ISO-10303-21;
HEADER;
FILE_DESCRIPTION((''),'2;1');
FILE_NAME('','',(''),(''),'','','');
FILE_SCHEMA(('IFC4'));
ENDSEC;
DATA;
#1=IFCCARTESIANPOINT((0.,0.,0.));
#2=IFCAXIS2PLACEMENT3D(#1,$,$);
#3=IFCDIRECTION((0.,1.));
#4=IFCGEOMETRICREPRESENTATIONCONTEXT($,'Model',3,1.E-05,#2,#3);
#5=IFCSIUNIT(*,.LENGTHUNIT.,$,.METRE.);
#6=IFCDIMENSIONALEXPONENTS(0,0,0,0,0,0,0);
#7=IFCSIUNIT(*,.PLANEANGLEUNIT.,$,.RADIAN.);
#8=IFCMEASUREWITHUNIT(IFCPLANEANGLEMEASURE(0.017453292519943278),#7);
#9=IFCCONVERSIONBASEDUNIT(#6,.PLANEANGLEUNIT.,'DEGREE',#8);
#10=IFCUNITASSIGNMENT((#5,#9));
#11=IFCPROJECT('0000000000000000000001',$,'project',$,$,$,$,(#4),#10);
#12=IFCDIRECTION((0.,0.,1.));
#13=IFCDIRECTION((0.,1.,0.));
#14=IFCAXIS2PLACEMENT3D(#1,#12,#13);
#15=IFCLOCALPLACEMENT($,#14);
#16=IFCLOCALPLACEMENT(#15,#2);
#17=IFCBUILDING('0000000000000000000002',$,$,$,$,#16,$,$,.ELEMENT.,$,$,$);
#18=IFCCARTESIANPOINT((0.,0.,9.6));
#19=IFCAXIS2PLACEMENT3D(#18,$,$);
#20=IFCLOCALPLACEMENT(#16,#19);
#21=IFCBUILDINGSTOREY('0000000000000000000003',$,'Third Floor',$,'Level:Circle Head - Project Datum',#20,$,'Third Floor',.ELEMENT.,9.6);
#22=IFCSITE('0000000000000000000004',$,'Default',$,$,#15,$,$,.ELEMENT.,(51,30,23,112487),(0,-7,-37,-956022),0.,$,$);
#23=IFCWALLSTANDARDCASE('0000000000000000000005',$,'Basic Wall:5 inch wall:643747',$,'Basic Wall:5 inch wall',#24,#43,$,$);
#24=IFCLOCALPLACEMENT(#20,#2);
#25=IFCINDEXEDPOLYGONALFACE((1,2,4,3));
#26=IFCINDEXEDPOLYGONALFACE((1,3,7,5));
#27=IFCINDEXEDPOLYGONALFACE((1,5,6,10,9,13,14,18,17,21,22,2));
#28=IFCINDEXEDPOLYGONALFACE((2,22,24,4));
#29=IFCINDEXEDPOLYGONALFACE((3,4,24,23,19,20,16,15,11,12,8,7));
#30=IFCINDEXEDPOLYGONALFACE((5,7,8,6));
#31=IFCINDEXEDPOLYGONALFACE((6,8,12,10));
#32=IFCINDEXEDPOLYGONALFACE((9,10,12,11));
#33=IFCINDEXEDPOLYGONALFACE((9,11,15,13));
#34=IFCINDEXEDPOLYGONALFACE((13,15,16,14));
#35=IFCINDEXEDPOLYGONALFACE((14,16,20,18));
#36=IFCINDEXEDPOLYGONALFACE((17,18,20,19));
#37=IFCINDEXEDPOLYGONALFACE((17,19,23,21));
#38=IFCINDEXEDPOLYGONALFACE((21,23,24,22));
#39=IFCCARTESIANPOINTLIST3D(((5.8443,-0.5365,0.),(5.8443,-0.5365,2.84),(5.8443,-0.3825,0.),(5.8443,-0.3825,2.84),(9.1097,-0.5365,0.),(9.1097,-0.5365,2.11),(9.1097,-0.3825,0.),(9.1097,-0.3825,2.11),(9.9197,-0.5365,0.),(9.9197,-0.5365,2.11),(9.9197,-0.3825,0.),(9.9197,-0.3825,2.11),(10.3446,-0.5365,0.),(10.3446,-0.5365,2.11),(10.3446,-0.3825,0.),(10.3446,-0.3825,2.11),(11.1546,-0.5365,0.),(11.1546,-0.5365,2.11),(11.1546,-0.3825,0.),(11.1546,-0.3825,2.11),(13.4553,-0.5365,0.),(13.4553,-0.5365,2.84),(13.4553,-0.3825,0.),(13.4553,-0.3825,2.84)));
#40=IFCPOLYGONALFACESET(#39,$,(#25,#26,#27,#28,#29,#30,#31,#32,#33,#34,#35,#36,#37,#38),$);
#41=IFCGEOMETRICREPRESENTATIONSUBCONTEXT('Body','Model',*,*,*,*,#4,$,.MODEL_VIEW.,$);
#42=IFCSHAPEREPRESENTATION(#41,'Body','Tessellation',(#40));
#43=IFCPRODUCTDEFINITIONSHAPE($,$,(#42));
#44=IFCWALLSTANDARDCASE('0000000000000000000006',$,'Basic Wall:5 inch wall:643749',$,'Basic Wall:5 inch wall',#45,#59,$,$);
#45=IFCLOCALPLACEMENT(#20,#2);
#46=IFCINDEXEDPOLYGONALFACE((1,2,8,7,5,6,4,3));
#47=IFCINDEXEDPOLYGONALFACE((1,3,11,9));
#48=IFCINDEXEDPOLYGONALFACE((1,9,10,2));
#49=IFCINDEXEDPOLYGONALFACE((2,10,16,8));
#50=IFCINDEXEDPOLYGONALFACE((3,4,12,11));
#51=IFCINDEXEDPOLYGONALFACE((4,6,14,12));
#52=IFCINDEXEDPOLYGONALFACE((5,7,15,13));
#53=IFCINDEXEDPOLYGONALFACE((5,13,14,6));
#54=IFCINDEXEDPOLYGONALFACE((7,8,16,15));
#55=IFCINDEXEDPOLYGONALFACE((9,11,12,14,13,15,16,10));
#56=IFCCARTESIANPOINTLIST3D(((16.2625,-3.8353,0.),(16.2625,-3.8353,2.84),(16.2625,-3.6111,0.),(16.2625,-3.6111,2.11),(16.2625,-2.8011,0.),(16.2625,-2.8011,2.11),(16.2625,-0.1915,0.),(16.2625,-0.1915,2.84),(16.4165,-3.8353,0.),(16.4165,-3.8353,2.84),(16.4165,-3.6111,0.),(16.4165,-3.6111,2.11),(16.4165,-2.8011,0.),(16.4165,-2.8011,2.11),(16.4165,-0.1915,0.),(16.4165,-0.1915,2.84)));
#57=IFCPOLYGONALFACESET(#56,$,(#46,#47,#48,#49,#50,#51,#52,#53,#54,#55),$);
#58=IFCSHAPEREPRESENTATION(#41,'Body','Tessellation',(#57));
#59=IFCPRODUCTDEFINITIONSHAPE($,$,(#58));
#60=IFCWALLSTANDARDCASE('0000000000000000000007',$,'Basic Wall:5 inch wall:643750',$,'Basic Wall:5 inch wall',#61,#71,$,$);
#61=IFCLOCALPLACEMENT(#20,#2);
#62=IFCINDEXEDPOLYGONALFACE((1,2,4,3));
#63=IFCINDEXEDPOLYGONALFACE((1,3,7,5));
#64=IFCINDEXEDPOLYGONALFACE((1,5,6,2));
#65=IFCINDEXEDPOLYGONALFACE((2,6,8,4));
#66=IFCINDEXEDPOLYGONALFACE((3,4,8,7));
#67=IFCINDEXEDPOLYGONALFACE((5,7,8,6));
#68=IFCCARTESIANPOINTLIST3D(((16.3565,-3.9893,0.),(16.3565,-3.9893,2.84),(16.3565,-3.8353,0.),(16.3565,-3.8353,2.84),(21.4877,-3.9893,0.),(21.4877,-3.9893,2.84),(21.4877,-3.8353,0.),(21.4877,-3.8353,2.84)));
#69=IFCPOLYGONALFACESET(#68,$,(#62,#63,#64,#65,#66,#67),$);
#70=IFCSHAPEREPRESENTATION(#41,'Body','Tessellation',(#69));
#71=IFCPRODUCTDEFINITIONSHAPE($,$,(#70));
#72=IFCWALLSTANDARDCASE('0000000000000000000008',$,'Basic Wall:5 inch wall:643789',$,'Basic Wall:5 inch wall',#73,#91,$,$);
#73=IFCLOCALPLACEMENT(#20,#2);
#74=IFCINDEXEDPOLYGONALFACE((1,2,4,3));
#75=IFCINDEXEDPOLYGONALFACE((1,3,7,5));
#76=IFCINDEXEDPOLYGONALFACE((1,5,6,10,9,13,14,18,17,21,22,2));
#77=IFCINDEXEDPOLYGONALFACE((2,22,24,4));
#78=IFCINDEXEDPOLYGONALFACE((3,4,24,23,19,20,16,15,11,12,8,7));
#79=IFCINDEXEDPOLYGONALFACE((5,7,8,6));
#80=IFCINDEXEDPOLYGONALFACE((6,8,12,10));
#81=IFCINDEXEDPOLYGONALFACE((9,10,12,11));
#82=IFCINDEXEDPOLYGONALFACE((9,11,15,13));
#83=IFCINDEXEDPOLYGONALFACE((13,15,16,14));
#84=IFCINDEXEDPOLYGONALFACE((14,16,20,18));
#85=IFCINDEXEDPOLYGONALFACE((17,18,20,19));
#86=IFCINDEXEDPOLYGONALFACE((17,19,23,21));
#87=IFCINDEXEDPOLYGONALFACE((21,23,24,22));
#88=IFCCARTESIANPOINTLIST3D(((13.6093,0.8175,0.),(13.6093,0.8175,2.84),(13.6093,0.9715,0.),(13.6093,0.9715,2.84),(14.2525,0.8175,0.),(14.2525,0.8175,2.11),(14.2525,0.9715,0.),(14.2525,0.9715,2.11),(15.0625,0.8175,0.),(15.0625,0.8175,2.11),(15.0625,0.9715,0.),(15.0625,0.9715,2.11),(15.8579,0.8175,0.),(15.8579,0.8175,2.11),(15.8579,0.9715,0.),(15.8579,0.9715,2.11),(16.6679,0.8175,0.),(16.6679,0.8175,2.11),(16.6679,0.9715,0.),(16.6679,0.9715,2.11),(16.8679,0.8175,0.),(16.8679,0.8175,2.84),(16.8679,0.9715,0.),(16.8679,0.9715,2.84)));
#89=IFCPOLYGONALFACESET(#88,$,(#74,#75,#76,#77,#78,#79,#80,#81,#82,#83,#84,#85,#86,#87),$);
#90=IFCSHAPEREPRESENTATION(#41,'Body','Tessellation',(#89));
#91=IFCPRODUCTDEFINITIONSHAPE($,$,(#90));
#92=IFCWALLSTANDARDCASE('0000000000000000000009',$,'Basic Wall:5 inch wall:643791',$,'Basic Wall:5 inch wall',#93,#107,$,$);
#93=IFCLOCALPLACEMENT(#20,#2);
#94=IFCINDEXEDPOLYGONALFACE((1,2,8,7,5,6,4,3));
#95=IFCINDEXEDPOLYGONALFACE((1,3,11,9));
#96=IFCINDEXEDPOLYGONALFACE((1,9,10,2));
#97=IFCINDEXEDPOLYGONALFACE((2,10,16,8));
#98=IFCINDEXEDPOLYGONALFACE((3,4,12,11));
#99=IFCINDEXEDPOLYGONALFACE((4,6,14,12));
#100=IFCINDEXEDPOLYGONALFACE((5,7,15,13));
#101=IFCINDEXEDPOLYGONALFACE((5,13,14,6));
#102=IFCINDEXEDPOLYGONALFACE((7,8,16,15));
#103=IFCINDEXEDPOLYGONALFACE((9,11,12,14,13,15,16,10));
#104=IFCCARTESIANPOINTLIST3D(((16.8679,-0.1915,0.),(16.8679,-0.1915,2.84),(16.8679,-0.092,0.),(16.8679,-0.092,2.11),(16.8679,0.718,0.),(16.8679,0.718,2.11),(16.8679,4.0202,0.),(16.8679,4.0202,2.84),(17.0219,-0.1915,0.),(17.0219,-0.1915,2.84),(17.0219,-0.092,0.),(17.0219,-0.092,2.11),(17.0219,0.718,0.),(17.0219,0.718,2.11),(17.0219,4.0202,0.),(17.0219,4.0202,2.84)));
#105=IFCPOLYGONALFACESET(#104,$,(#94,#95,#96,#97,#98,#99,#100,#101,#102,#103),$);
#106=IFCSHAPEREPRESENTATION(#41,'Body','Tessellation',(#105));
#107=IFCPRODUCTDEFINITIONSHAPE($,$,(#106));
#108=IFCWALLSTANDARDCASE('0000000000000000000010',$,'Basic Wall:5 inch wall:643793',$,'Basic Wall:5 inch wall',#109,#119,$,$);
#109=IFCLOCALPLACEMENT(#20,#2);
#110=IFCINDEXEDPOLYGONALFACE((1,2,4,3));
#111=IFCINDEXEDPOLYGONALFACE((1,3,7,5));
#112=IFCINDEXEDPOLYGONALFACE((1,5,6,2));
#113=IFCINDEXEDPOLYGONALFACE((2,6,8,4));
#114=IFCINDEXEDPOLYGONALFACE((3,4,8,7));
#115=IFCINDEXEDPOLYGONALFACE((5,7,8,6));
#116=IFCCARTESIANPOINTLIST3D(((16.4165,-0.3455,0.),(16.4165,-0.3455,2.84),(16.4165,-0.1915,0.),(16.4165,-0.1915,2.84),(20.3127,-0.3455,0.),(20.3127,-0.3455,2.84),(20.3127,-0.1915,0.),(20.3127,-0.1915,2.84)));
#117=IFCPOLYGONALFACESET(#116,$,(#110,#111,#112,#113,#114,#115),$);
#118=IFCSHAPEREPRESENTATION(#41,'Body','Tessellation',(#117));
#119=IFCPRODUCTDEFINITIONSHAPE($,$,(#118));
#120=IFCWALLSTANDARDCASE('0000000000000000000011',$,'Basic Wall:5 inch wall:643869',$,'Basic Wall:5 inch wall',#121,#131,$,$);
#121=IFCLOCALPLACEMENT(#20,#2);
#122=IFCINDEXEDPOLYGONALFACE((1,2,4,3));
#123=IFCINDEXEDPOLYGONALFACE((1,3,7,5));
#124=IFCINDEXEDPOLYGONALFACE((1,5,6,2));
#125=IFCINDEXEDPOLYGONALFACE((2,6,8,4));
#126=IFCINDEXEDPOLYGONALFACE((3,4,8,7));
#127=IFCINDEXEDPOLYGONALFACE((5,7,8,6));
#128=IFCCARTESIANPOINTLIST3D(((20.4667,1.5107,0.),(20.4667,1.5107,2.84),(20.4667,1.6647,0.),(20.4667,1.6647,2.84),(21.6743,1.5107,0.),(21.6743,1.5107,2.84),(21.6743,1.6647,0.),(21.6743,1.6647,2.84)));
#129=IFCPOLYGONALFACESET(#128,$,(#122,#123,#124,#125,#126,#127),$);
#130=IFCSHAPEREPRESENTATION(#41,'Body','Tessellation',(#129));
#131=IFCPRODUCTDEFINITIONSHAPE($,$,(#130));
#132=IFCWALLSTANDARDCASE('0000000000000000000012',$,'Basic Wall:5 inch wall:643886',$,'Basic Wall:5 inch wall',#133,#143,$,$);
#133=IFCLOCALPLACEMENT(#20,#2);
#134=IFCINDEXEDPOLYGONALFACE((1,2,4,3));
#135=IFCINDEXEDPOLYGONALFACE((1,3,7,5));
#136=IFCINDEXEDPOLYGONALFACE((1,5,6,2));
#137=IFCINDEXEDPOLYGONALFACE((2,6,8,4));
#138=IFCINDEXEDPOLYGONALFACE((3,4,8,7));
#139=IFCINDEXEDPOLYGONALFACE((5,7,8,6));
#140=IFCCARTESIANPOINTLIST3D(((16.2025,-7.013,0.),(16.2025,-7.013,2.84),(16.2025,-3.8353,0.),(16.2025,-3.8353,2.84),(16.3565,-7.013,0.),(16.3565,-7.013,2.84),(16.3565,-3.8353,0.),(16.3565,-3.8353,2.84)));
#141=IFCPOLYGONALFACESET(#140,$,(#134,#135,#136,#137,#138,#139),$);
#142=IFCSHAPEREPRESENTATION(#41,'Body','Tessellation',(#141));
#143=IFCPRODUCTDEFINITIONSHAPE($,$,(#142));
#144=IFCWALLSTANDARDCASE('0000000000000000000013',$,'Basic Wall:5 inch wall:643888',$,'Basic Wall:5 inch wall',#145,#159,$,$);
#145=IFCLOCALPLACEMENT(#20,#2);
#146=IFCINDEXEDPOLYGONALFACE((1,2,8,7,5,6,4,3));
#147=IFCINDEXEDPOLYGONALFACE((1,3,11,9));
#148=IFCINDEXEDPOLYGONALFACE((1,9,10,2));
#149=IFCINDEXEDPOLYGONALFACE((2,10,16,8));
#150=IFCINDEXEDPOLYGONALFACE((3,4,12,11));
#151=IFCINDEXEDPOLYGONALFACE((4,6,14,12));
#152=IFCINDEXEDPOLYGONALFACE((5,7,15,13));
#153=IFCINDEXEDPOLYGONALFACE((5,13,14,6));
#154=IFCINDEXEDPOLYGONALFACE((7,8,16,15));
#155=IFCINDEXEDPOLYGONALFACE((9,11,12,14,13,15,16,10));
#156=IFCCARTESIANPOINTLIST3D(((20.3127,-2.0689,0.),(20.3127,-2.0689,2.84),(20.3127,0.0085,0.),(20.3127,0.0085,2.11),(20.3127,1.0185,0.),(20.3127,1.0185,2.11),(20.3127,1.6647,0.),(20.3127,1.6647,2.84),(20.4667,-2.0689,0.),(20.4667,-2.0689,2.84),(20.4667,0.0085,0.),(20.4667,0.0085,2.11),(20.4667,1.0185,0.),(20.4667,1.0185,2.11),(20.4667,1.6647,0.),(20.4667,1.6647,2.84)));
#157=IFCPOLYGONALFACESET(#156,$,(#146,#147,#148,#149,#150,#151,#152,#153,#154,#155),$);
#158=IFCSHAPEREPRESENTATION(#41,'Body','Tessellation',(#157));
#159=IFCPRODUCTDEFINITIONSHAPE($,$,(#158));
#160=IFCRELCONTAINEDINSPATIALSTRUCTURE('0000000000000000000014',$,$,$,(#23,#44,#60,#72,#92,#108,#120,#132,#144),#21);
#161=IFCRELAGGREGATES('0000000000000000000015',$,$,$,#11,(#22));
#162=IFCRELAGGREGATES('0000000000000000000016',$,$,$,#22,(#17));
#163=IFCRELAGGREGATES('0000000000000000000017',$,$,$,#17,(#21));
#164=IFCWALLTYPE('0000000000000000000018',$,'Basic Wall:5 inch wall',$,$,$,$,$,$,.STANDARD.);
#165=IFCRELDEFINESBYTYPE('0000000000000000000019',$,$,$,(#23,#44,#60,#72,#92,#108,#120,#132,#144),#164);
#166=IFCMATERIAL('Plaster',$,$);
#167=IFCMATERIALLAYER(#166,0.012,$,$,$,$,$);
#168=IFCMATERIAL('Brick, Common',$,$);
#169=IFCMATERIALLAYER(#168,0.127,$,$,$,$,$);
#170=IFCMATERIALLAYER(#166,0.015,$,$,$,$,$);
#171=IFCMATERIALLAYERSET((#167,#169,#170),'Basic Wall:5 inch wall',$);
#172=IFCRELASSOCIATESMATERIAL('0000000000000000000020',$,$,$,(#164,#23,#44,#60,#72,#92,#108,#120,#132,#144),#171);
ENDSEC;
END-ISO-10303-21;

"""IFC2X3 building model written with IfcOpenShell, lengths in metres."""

from ifc_helpers import new_model, entity, si_unit, converted_unit, direction, frame, frame_2d, origin, place, context, subcontext, project, spatial, rectangle, extrude, material, layer, layer_set, layer_usage, type_object, element, save


model = new_model("IFC2X3")

# Units and contexts
model_context = context("Model", 3, precision=1e-05, world=origin(), true_north=direction((0.0, 1.0)))
body_context = subcontext(model_context, "Body", "Model", "MODEL_VIEW")
ifc_project = project(units=[si_unit("LENGTHUNIT", "METRE"), converted_unit("PLANEANGLEUNIT", "DEGREE", entity("IfcPlaneAngleMeasure", 0.017453292519943278), si_unit("PLANEANGLEUNIT", "RADIAN"), dimensions=[0, 0, 0, 0, 0, 0, 0])], contexts=[model_context])

# Site, building, storey
site_placement = place(None, frame((0.0, 0.0, 0.0), z_axis=(0.0, 0.0, 1.0), x_axis=(0.0, 1.0, 0.0)))
site = spatial("IfcSite", under=ifc_project, at=site_placement, Name="Default", CompositionType="ELEMENT", RefLatitude=(51, 30, 23, 112487), RefLongitude=(0, -7, -37, -956022), RefElevation=0.0)
building_placement = place(site_placement, origin())
building = spatial("IfcBuilding", under=site, at=building_placement, CompositionType="ELEMENT")
storey_placement = place(building_placement, frame((0.0, 0.0, 9.6)))
storey = spatial("IfcBuildingStorey", under=building, at=storey_placement, Name="Third Floor", ObjectType="Level:Circle Head - Project Datum", LongName="Third Floor", CompositionType="ELEMENT", Elevation=9.6)

# Wall, openings
ifc_material_1 = material(Name="Plaster")
ifc_layer_1 = layer(ifc_material_1, 0.012)
ifc_material_2 = material(Name="Brick, Common")
ifc_layer_2 = layer(ifc_material_2, 0.127)
ifc_layer_3 = layer(ifc_material_1, 0.015)
ifc_layer_set = layer_set([ifc_layer_1, ifc_layer_2, ifc_layer_3], Name="Basic Wall:5 inch wall")
ifc_layer_usage_1 = layer_usage(ifc_layer_set, "AXIS2", "NEGATIVE", 0.077)
wall_type = type_object("IfcWallType", Name="Basic Wall:5 inch wall", PredefinedType="STANDARD", material=ifc_layer_set)
wall_1_placement = place(storey_placement, frame((13.4553, -0.4595, 0.0), z_axis=(0.0, 0.0, 1.0), x_axis=(-1.0, 0.0, 0.0)))
wall_1 = element("IfcWallStandardCase", 1, at=wall_1_placement, inside=storey, type_object=wall_type, material=ifc_layer_usage_1, Name="Basic Wall:5 inch wall:643747", ObjectType="Basic Wall:5 inch wall", context=body_context, shape_type="SweptSolid", body=[
    extrude(rectangle(XDim=7.611, YDim=0.154, at=frame_2d((3.8055, 0.0), x_axis=(1.0, 0.0))), origin(), (0.0, 0.0, 1.0), 2.84),
])
opening_1_placement = place(wall_1_placement, frame((4.3456, 0.077, 0.0)))
element("IfcOpeningElement", 2, at=opening_1_placement, cuts=wall_1, ObjectType="Opening", context=body_context, shape_type="SweptSolid", body=[
    extrude(rectangle(XDim=2.11, YDim=0.81, at=frame_2d((1.055, 0.405), x_axis=(1.0, 0.0))), frame((0.0, 0.0, 0.0), z_axis=(0.0, -1.0, 0.0), x_axis=(0.0, 0.0, 1.0)), (0.0, 0.0, 1.0), 0.154),
])
opening_2_placement = place(wall_1_placement, frame((3.1107, 0.077, 0.0)))
element("IfcOpeningElement", 3, at=opening_2_placement, cuts=wall_1, ObjectType="Opening", context=body_context, shape_type="SweptSolid", body=[
    extrude(rectangle(XDim=2.11, YDim=0.81, at=frame_2d((1.055, 0.405), x_axis=(1.0, 0.0))), frame((0.0, 0.0, 0.0), z_axis=(0.0, -1.0, 0.0), x_axis=(0.0, 0.0, 1.0)), (0.0, 0.0, 1.0), 0.154),
])

# Wall, opening
ifc_layer_usage_2 = layer_usage(ifc_layer_set, "AXIS2", "NEGATIVE", 0.077)
wall_2_placement = place(storey_placement, frame((16.3395, -0.1915, 0.0), z_axis=(0.0, 0.0, 1.0), x_axis=(0.0, -1.0, 0.0)))
wall_2 = element("IfcWallStandardCase", 4, at=wall_2_placement, inside=storey, type_object=wall_type, material=ifc_layer_usage_2, Name="Basic Wall:5 inch wall:643749", ObjectType="Basic Wall:5 inch wall", context=body_context, shape_type="SweptSolid", body=[
    extrude(rectangle(XDim=3.6438, YDim=0.154, at=frame_2d((1.8219, 0.0), x_axis=(1.0, 0.0))), origin(), (0.0, 0.0, 1.0), 2.84),
])
opening_3_placement = place(wall_2_placement, frame((3.4196, 0.077, 0.0)))
element("IfcOpeningElement", 5, at=opening_3_placement, cuts=wall_2, ObjectType="Opening", context=body_context, shape_type="SweptSolid", body=[
    extrude(rectangle(XDim=2.11, YDim=0.81, at=frame_2d((1.055, 0.405), x_axis=(1.0, 0.0))), frame((0.0, 0.0, 0.0), z_axis=(0.0, -1.0, 0.0), x_axis=(0.0, 0.0, 1.0)), (0.0, 0.0, 1.0), 0.154),
])

# Wall
ifc_layer_usage_3 = layer_usage(ifc_layer_set, "AXIS2", "NEGATIVE", 0.077)
wall_3_placement = place(storey_placement, frame((16.3565, -3.9123, 0.0)))
element("IfcWallStandardCase", 6, at=wall_3_placement, inside=storey, type_object=wall_type, material=ifc_layer_usage_3, Name="Basic Wall:5 inch wall:643750", ObjectType="Basic Wall:5 inch wall", context=body_context, shape_type="SweptSolid", body=[
    extrude(rectangle(XDim=5.1312, YDim=0.154, at=frame_2d((2.5656, 0.0), x_axis=(-1.0, 0.0))), origin(), (0.0, 0.0, 1.0), 2.84),
])

# Wall, openings
ifc_layer_usage_4 = layer_usage(ifc_layer_set, "AXIS2", "NEGATIVE", 0.077)
wall_4_placement = place(storey_placement, frame((13.6093, 0.8945, 0.0)))
wall_4 = element("IfcWallStandardCase", 7, at=wall_4_placement, inside=storey, type_object=wall_type, material=ifc_layer_usage_4, Name="Basic Wall:5 inch wall:643789", ObjectType="Basic Wall:5 inch wall", context=body_context, shape_type="SweptSolid", body=[
    extrude(rectangle(XDim=3.2586, YDim=0.154, at=frame_2d((1.6293, 0.0), x_axis=(-1.0, 0.0))), origin(), (0.0, 0.0, 1.0), 2.84),
])
opening_4_placement = place(wall_4_placement, frame((1.4532, 0.077, 0.0)))
element("IfcOpeningElement", 8, at=opening_4_placement, cuts=wall_4, ObjectType="Opening", context=body_context, shape_type="SweptSolid", body=[
    extrude(rectangle(XDim=2.11, YDim=0.81, at=frame_2d((1.055, 0.405), x_axis=(1.0, 0.0))), frame((0.0, 0.0, 0.0), z_axis=(0.0, -1.0, 0.0), x_axis=(0.0, 0.0, 1.0)), (0.0, 0.0, 1.0), 0.154),
])
opening_5_placement = place(wall_4_placement, frame((2.2486, -0.077, 0.0)))
element("IfcOpeningElement", 9, at=opening_5_placement, cuts=wall_4, ObjectType="Opening", context=body_context, shape_type="SweptSolid", body=[
    extrude(rectangle(XDim=2.11, YDim=0.81, at=frame_2d((1.055, 0.405), x_axis=(1.0, 0.0))), frame((0.0, 0.0, 0.0), z_axis=(0.0, 1.0, 0.0), x_axis=(0.0, 0.0, 1.0)), (0.0, 0.0, 1.0), 0.154),
])

# Wall, opening
ifc_layer_usage_5 = layer_usage(ifc_layer_set, "AXIS2", "NEGATIVE", 0.077)
wall_5_placement = place(storey_placement, frame((16.9449, -0.1915, 0.0), z_axis=(0.0, 0.0, 1.0), x_axis=(0.0, 1.0, 0.0)))
wall_5 = element("IfcWallStandardCase", 10, at=wall_5_placement, inside=storey, type_object=wall_type, material=ifc_layer_usage_5, Name="Basic Wall:5 inch wall:643791", ObjectType="Basic Wall:5 inch wall", context=body_context, shape_type="SweptSolid", body=[
    extrude(rectangle(XDim=4.2118, YDim=0.154, at=frame_2d((2.1059, 0.0), x_axis=(-1.0, 0.0))), origin(), (0.0, 0.0, 1.0), 2.84),
])
opening_6_placement = place(wall_5_placement, frame((0.9095, 0.077, 0.0)))
element("IfcOpeningElement", 11, at=opening_6_placement, cuts=wall_5, ObjectType="Opening", context=body_context, shape_type="SweptSolid", body=[
    extrude(rectangle(XDim=2.11, YDim=0.81, at=frame_2d((1.055, 0.405), x_axis=(1.0, 0.0))), frame((0.0, 0.0, 0.0), z_axis=(0.0, -1.0, 0.0), x_axis=(0.0, 0.0, 1.0)), (0.0, 0.0, 1.0), 0.154),
])

# Wall
ifc_layer_usage_6 = layer_usage(ifc_layer_set, "AXIS2", "NEGATIVE", 0.077)
wall_6_placement = place(storey_placement, frame((16.4165, -0.2685, 0.0)))
element("IfcWallStandardCase", 12, at=wall_6_placement, inside=storey, type_object=wall_type, material=ifc_layer_usage_6, Name="Basic Wall:5 inch wall:643793", ObjectType="Basic Wall:5 inch wall", context=body_context, shape_type="SweptSolid", body=[
    extrude(rectangle(XDim=3.8962, YDim=0.154, at=frame_2d((1.9481, 0.0), x_axis=(-1.0, 0.0))), origin(), (0.0, 0.0, 1.0), 2.84),
])

# Walls
ifc_layer_usage_7 = layer_usage(ifc_layer_set, "AXIS2", "NEGATIVE", 0.077)
wall_7_placement = place(storey_placement, frame((21.6743, 1.5877, 0.0), z_axis=(0.0, 0.0, 1.0), x_axis=(-1.0, 0.0, 0.0)))
element("IfcWallStandardCase", 13, at=wall_7_placement, inside=storey, type_object=wall_type, material=ifc_layer_usage_7, Name="Basic Wall:5 inch wall:643869", ObjectType="Basic Wall:5 inch wall", context=body_context, shape_type="SweptSolid", body=[
    extrude(rectangle(XDim=1.2076, YDim=0.154, at=frame_2d((0.6038, 0.0), x_axis=(-1.0, 0.0))), origin(), (0.0, 0.0, 1.0), 2.84),
])
ifc_layer_usage_8 = layer_usage(ifc_layer_set, "AXIS2", "NEGATIVE", 0.077)
wall_8_placement = place(storey_placement, frame((16.2795, -3.8353, 0.0), z_axis=(0.0, 0.0, 1.0), x_axis=(0.0, -1.0, 0.0)))
element("IfcWallStandardCase", 14, at=wall_8_placement, inside=storey, type_object=wall_type, material=ifc_layer_usage_8, Name="Basic Wall:5 inch wall:643886", ObjectType="Basic Wall:5 inch wall", context=body_context, shape_type="SweptSolid", body=[
    extrude(rectangle(XDim=3.1777, YDim=0.154, at=frame_2d((1.5888, 0.0), x_axis=(-1.0, 0.0))), origin(), (0.0, 0.0, 1.0), 2.84),
])

# Wall, opening
ifc_layer_usage_9 = layer_usage(ifc_layer_set, "AXIS2", "NEGATIVE", 0.077)
wall_9_placement = place(storey_placement, frame((20.3897, 1.6647, 0.0), z_axis=(0.0, 0.0, 1.0), x_axis=(0.0, -1.0, 0.0)))
wall_9 = element("IfcWallStandardCase", 15, at=wall_9_placement, inside=storey, type_object=wall_type, material=ifc_layer_usage_9, Name="Basic Wall:5 inch wall:643888", ObjectType="Basic Wall:5 inch wall", context=body_context, shape_type="SweptSolid", body=[
    extrude(rectangle(XDim=3.7336, YDim=0.154, at=frame_2d((1.8668, 0.0), x_axis=(1.0, 0.0))), origin(), (0.0, 0.0, 1.0), 2.84),
])
opening_7_placement = place(wall_9_placement, frame((1.6562, 0.077, 0.0)))
element("IfcOpeningElement", 16, at=opening_7_placement, cuts=wall_9, ObjectType="Opening", context=body_context, shape_type="SweptSolid", body=[
    extrude(rectangle(XDim=2.11, YDim=1.01, at=frame_2d((1.055, 0.505), x_axis=(1.0, 0.0))), frame((0.0, 0.0, 0.0), z_axis=(0.0, -1.0, 0.0), x_axis=(0.0, 0.0, 1.0)), (0.0, 0.0, 1.0), 0.154),
])

save(model, "model.ifc")
